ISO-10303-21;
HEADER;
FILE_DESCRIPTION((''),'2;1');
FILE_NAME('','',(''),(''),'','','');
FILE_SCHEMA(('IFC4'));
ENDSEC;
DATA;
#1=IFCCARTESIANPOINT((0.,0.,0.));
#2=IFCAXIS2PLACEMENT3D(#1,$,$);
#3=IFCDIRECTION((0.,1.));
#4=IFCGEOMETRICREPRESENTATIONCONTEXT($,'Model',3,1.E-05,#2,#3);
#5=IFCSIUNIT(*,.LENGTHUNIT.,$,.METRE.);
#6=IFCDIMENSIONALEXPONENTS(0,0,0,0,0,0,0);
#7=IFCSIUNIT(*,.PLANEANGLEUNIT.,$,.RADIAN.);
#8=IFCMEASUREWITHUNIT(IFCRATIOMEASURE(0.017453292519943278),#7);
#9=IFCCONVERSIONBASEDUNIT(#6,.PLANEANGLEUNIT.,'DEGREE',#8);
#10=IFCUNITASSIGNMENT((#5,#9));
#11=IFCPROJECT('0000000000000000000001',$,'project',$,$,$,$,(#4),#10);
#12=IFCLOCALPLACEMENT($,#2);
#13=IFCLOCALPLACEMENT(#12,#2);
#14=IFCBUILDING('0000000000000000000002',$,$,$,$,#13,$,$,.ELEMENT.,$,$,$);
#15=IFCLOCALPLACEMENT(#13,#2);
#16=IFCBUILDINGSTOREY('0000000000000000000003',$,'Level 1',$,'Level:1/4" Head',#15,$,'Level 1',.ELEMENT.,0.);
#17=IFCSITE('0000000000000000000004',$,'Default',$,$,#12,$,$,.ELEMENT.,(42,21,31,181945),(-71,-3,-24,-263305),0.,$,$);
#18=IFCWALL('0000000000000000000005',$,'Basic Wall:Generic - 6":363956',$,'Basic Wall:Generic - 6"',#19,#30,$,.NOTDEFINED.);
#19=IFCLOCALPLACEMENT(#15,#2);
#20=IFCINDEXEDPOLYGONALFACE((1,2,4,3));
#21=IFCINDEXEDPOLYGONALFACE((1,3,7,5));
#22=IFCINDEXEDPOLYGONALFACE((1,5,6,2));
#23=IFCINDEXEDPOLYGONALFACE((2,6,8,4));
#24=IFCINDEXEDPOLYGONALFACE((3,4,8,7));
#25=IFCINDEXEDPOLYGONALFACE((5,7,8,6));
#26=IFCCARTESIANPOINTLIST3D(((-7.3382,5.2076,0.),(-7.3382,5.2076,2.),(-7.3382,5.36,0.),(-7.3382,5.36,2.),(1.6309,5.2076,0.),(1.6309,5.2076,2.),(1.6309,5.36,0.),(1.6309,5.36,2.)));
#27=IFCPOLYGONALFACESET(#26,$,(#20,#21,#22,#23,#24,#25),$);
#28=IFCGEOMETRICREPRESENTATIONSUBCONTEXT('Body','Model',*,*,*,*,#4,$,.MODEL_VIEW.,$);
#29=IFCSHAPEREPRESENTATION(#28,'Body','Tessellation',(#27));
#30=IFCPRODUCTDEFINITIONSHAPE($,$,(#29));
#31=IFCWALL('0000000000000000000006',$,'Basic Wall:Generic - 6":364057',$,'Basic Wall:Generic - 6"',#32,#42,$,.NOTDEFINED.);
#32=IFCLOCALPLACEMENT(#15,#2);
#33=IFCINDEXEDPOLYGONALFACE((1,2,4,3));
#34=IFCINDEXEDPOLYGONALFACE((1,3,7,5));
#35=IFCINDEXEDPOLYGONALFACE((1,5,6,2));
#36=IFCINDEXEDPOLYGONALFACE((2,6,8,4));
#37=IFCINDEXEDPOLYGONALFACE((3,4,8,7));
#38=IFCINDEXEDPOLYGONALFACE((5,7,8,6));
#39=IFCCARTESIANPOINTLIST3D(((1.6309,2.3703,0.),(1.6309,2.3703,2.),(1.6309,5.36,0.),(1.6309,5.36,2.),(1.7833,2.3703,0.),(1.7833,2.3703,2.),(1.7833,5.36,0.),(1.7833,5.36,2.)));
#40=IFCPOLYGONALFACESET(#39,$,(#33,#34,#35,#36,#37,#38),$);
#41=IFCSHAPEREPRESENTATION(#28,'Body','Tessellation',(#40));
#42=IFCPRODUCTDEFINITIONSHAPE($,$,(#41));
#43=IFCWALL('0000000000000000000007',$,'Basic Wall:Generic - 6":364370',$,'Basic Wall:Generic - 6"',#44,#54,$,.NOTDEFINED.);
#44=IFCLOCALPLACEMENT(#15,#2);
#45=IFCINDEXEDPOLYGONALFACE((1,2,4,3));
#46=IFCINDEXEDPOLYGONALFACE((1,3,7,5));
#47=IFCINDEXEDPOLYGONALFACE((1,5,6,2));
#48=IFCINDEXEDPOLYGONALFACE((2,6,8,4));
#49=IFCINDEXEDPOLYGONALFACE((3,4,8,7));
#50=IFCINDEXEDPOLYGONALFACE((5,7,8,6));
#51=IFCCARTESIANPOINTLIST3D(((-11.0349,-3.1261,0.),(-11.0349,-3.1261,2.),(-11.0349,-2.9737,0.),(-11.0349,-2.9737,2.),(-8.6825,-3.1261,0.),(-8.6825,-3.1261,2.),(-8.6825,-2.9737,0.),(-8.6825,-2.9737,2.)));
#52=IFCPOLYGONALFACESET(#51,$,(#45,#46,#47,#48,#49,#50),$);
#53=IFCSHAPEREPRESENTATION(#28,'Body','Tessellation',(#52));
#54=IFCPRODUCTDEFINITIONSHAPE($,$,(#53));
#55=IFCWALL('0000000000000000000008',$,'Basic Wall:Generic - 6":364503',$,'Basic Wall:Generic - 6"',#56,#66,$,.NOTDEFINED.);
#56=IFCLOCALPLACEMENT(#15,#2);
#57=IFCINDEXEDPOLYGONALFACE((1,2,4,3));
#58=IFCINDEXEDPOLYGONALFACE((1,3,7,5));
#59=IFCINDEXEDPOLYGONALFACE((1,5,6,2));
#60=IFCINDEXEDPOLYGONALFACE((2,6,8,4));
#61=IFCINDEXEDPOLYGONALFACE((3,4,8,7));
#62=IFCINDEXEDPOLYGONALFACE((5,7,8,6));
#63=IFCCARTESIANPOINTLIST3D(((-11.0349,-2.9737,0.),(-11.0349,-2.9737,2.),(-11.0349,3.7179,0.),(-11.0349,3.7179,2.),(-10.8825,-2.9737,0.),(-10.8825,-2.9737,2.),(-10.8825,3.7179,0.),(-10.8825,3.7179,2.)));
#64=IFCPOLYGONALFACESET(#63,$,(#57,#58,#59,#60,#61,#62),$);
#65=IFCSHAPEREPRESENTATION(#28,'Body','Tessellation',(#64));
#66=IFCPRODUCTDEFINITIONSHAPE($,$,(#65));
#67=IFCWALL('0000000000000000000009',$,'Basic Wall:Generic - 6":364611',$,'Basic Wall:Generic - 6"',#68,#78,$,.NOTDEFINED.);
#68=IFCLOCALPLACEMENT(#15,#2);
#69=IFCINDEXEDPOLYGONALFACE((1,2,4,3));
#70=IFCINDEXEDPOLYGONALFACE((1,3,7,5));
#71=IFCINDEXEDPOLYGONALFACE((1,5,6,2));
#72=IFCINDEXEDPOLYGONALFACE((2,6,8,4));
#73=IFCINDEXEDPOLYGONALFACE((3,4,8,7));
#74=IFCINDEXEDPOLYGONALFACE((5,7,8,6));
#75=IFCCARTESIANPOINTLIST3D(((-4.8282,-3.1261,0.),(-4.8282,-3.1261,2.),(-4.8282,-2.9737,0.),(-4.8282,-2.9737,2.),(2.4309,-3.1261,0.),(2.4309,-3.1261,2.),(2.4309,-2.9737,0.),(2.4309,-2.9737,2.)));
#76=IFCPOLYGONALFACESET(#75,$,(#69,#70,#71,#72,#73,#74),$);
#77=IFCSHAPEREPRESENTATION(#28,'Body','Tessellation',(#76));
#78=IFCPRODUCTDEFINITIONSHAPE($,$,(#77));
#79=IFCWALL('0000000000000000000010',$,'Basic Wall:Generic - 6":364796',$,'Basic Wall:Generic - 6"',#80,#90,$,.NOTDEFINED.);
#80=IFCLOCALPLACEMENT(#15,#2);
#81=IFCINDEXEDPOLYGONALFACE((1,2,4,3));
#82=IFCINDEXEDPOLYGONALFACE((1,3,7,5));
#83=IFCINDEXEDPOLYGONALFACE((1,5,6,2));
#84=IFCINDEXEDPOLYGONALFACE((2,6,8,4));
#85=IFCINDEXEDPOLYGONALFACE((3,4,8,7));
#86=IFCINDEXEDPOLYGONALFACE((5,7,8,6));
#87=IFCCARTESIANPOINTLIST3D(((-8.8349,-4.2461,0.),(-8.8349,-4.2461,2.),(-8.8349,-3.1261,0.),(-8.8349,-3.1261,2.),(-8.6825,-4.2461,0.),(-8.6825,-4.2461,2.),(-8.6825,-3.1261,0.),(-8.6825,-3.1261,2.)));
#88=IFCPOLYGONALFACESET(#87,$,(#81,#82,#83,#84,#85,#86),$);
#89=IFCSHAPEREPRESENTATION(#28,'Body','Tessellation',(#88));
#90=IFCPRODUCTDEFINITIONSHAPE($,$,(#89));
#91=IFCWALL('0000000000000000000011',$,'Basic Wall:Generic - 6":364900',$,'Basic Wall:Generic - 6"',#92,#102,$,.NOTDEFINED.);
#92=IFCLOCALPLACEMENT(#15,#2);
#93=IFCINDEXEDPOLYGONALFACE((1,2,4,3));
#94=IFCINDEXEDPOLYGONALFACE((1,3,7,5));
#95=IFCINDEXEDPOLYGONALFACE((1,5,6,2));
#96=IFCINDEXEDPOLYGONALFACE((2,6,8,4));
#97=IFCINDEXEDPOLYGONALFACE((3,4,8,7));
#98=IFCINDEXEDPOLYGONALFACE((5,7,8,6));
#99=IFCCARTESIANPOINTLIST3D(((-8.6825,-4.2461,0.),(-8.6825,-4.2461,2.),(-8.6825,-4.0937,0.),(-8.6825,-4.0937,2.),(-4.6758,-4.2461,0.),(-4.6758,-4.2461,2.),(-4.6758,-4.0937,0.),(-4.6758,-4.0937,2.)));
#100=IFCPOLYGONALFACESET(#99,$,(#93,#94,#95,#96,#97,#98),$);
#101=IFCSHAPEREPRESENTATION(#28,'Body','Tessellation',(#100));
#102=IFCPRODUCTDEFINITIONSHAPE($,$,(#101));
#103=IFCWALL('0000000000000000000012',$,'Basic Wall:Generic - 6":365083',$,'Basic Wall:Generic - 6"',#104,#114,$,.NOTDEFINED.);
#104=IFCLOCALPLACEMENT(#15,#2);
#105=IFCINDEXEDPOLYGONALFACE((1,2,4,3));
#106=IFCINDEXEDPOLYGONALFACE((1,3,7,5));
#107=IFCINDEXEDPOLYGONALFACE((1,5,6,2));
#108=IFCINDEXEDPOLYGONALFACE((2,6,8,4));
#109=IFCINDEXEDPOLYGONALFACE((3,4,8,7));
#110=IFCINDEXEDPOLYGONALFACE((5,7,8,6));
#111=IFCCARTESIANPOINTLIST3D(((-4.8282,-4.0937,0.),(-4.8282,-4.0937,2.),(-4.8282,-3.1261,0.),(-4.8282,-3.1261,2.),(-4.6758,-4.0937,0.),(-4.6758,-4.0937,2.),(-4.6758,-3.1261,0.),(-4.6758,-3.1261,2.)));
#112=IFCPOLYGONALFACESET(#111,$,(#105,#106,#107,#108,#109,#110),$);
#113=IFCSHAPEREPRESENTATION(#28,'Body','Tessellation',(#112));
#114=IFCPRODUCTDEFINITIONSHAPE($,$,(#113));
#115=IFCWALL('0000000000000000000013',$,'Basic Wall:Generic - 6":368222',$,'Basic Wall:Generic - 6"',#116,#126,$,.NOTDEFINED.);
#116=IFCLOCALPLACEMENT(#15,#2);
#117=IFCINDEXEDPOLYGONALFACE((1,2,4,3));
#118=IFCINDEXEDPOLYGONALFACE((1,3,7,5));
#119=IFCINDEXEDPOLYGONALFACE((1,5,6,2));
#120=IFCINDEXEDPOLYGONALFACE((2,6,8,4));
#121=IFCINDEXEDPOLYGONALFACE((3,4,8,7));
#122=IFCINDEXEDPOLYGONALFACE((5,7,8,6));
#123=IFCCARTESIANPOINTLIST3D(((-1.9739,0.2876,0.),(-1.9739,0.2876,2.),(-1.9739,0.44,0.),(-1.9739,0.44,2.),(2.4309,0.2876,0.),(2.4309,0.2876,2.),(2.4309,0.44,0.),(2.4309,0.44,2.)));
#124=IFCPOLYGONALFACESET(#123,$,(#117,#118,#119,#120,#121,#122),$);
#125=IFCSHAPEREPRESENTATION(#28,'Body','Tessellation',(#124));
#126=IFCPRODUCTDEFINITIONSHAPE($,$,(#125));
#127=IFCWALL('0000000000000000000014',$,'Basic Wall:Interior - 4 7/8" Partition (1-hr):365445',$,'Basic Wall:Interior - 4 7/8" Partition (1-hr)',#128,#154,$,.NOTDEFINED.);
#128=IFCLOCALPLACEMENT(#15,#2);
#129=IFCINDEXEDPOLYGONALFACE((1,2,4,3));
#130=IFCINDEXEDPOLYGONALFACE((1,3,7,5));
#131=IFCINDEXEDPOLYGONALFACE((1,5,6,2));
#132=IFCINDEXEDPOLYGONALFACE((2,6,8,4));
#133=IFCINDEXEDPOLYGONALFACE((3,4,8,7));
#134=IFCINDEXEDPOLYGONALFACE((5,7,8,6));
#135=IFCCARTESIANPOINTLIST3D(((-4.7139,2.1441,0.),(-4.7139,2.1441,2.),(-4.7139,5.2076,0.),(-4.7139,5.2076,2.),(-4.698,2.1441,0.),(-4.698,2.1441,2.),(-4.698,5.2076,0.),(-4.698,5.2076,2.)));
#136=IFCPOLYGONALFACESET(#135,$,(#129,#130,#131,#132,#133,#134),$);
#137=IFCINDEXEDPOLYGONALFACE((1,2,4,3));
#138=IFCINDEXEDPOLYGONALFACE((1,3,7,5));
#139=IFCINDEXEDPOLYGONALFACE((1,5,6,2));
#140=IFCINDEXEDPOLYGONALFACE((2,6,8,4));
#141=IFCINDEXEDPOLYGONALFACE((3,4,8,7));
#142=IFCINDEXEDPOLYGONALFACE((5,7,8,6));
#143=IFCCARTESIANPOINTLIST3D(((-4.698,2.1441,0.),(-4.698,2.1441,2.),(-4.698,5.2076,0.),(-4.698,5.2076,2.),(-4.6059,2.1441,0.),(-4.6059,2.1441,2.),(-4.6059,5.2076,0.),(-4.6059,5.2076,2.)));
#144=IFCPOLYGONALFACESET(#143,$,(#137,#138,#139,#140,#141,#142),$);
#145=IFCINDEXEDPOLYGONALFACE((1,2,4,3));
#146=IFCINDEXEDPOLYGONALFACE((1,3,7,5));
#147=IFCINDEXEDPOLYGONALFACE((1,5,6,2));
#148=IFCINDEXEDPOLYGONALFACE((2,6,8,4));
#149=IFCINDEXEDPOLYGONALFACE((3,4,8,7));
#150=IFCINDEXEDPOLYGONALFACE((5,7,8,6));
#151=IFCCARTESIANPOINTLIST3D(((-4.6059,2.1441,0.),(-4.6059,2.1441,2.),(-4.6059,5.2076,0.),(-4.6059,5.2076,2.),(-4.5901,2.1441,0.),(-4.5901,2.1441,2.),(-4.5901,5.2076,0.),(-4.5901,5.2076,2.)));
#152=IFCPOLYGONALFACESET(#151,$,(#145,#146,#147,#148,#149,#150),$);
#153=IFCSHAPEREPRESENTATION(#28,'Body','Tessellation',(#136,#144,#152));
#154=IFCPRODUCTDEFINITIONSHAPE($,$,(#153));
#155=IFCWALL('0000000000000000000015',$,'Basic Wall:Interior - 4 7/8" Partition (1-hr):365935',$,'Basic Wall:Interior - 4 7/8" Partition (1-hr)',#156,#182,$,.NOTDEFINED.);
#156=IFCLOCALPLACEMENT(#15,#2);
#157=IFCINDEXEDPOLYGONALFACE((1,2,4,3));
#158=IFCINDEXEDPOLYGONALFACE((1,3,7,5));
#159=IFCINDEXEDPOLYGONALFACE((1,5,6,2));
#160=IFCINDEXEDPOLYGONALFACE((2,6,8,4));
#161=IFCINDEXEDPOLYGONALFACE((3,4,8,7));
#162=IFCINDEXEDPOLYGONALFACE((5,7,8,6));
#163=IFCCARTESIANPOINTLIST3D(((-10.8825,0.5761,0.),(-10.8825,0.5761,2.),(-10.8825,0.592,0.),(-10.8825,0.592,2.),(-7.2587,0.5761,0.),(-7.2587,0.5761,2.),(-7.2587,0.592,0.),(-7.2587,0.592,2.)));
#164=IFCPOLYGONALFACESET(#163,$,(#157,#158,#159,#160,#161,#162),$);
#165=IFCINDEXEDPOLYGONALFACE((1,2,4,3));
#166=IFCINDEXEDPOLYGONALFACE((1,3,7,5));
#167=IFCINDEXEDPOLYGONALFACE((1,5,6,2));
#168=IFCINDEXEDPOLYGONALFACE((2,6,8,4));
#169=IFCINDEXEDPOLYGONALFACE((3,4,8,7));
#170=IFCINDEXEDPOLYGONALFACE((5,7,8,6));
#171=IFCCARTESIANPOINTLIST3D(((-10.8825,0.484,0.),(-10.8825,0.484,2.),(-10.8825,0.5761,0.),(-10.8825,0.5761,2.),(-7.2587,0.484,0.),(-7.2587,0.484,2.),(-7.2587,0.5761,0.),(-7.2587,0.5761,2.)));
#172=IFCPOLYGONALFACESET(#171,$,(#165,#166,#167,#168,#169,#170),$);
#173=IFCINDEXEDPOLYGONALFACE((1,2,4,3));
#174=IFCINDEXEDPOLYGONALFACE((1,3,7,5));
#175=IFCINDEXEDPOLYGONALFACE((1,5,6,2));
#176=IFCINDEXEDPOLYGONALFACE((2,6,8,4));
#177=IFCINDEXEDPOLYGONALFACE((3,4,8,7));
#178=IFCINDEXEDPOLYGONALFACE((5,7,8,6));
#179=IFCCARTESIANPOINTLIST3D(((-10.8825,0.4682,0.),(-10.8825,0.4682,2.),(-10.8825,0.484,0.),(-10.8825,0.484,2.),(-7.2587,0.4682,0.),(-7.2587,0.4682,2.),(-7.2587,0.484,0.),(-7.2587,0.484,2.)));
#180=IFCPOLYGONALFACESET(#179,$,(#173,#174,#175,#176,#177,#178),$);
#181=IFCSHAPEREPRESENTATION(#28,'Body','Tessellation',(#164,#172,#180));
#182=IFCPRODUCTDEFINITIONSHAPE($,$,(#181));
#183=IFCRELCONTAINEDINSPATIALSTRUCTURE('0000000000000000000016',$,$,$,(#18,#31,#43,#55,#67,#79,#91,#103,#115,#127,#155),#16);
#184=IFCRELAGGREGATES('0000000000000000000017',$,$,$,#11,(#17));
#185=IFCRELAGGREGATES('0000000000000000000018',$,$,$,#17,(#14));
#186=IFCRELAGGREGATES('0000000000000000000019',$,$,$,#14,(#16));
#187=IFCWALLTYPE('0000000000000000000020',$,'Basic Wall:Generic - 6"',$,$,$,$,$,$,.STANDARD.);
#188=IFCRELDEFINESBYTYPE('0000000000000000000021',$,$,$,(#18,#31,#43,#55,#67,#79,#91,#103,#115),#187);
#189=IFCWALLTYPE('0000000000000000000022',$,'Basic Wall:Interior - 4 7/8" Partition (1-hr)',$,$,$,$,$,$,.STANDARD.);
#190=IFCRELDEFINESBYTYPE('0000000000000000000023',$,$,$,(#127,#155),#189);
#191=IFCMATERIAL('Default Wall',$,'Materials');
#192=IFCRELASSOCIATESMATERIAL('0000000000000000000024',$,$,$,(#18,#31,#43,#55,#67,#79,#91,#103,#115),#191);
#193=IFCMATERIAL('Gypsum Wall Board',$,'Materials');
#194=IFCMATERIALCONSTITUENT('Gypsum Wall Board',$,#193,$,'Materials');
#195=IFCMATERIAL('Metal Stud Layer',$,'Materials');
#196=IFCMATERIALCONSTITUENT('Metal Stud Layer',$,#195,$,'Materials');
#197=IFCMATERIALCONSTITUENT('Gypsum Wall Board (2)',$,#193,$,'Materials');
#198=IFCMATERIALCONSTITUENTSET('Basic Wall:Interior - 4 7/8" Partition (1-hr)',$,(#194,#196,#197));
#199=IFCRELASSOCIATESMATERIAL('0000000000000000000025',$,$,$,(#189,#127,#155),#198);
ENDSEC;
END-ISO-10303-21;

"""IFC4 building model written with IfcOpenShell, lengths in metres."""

from ifc_helpers import new_model, entity, si_unit, converted_unit, direction, frame, origin, place, context, subcontext, project, spatial, indexed_curve, outline, extrude, material, constituent, constituent_set, type_object, element, save


model = new_model("IFC4")

# Units and contexts
model_context = context("Model", 3, precision=1e-05, world=origin(), true_north=direction((0.0, 1.0)))
body_context = subcontext(model_context, "Body", "Model", "MODEL_VIEW")
ifc_project = project(units=[si_unit("LENGTHUNIT", "METRE"), converted_unit("PLANEANGLEUNIT", "DEGREE", entity("IfcRatioMeasure", 0.017453292519943278), si_unit("PLANEANGLEUNIT", "RADIAN"), dimensions=[0, 0, 0, 0, 0, 0, 0])], contexts=[model_context])

# Site, building, storey
site_placement = place(None, origin())
site = spatial("IfcSite", under=ifc_project, at=site_placement, Name="Default", CompositionType="ELEMENT", RefLatitude=(42, 21, 31, 181945), RefLongitude=(-71, -3, -24, -263305), RefElevation=0.0)
building_placement = place(site_placement, origin())
building = spatial("IfcBuilding", under=site, at=building_placement, CompositionType="ELEMENT")
storey_placement = place(building_placement, origin())
storey = spatial("IfcBuildingStorey", under=building, at=storey_placement, Name="Level 1", ObjectType="Level:1/4\" Head", LongName="Level 1", CompositionType="ELEMENT", Elevation=0.0)

# Walls
ifc_material_1 = material(Name="Default Wall", Category="Materials")
wall_type_1 = type_object("IfcWallType", Name="Basic Wall:Generic - 6\"", PredefinedType="STANDARD")
wall_1_placement = place(storey_placement, frame((1.6309, 5.2838, 0.0), z_axis=(0.0, 0.0, 1.0), x_axis=(-1.0, 0.0, 0.0)))
element("IfcWall", 1, at=wall_1_placement, inside=storey, type_object=wall_type_1, material=ifc_material_1, Name="Basic Wall:Generic - 6\":363956", ObjectType="Basic Wall:Generic - 6\"", PredefinedType="NOTDEFINED", context=body_context, shape_type="SweptSolid", body=[
    extrude(outline(indexed_curve([(8.9691, 0.0762), (0.0, 0.0762), (0.0, -0.0762), (8.9691, -0.0762), (8.9691, 0.0762)], self_intersect=False)), origin(), (0.0, 0.0, 1.0), 2.0),
])
wall_2_placement = place(storey_placement, frame((1.7071, 5.36, 0.0), z_axis=(0.0, 0.0, 1.0), x_axis=(0.0, -1.0, 0.0)))
element("IfcWall", 2, at=wall_2_placement, inside=storey, type_object=wall_type_1, material=ifc_material_1, Name="Basic Wall:Generic - 6\":364057", ObjectType="Basic Wall:Generic - 6\"", PredefinedType="NOTDEFINED", context=body_context, shape_type="SweptSolid", body=[
    extrude(outline(indexed_curve([(2.9897, 0.0762), (0.0, 0.0762), (0.0, -0.0762), (2.9897, -0.0762), (2.9897, 0.0762)], self_intersect=False)), origin(), (0.0, 0.0, 1.0), 2.0),
])
wall_3_placement = place(storey_placement, frame((-8.6825, -3.0499, 0.0), z_axis=(0.0, 0.0, 1.0), x_axis=(-1.0, 0.0, 0.0)))
element("IfcWall", 3, at=wall_3_placement, inside=storey, type_object=wall_type_1, material=ifc_material_1, Name="Basic Wall:Generic - 6\":364370", ObjectType="Basic Wall:Generic - 6\"", PredefinedType="NOTDEFINED", context=body_context, shape_type="SweptSolid", body=[
    extrude(outline(indexed_curve([(2.3524, 0.0762), (0.0, 0.0762), (0.0, -0.0762), (2.3524, -0.0762), (2.3524, 0.0762)], self_intersect=False)), origin(), (0.0, 0.0, 1.0), 2.0),
])
wall_4_placement = place(storey_placement, frame((-10.9587, 3.7179, 0.0), z_axis=(0.0, 0.0, 1.0), x_axis=(0.0, -1.0, 0.0)))
element("IfcWall", 4, at=wall_4_placement, inside=storey, type_object=wall_type_1, material=ifc_material_1, Name="Basic Wall:Generic - 6\":364503", ObjectType="Basic Wall:Generic - 6\"", PredefinedType="NOTDEFINED", context=body_context, shape_type="SweptSolid", body=[
    extrude(outline(indexed_curve([(6.6916, 0.0762), (0.0, 0.0762), (0.0, -0.0762), (6.6916, -0.0762), (6.6916, 0.0762)], self_intersect=False)), origin(), (0.0, 0.0, 1.0), 2.0),
])
wall_5_placement = place(storey_placement, frame((2.4309, -3.0499, 0.0), z_axis=(0.0, 0.0, 1.0), x_axis=(-1.0, 0.0, 0.0)))
element("IfcWall", 5, at=wall_5_placement, inside=storey, type_object=wall_type_1, material=ifc_material_1, Name="Basic Wall:Generic - 6\":364611", ObjectType="Basic Wall:Generic - 6\"", PredefinedType="NOTDEFINED", context=body_context, shape_type="SweptSolid", body=[
    extrude(outline(indexed_curve([(7.2591, 0.0762), (0.0, 0.0762), (0.0, -0.0762), (7.2591, -0.0762), (7.2591, 0.0762)], self_intersect=False)), origin(), (0.0, 0.0, 1.0), 2.0),
])
wall_6_placement = place(storey_placement, frame((-8.7587, -3.1261, 0.0), z_axis=(0.0, 0.0, 1.0), x_axis=(0.0, -1.0, 0.0)))
element("IfcWall", 6, at=wall_6_placement, inside=storey, type_object=wall_type_1, material=ifc_material_1, Name="Basic Wall:Generic - 6\":364796", ObjectType="Basic Wall:Generic - 6\"", PredefinedType="NOTDEFINED", context=body_context, shape_type="SweptSolid", body=[
    extrude(outline(indexed_curve([(1.12, 0.0762), (0.0, 0.0762), (0.0, -0.0762), (1.12, -0.0762), (1.12, 0.0762)], self_intersect=False)), origin(), (0.0, 0.0, 1.0), 2.0),
])
wall_7_placement = place(storey_placement, frame((-4.6758, -4.1699, 0.0), z_axis=(0.0, 0.0, 1.0), x_axis=(-1.0, 0.0, 0.0)))
element("IfcWall", 7, at=wall_7_placement, inside=storey, type_object=wall_type_1, material=ifc_material_1, Name="Basic Wall:Generic - 6\":364900", ObjectType="Basic Wall:Generic - 6\"", PredefinedType="NOTDEFINED", context=body_context, shape_type="SweptSolid", body=[
    extrude(outline(indexed_curve([(4.0068, 0.0762), (0.0, 0.0762), (0.0, -0.0762), (4.0068, -0.0762), (4.0068, 0.0762)], self_intersect=False)), origin(), (0.0, 0.0, 1.0), 2.0),
])
wall_8_placement = place(storey_placement, frame((-4.752, -4.0937, 0.0), z_axis=(0.0, 0.0, 1.0), x_axis=(0.0, 1.0, 0.0)))
element("IfcWall", 8, at=wall_8_placement, inside=storey, type_object=wall_type_1, material=ifc_material_1, Name="Basic Wall:Generic - 6\":365083", ObjectType="Basic Wall:Generic - 6\"", PredefinedType="NOTDEFINED", context=body_context, shape_type="SweptSolid", body=[
    extrude(outline(indexed_curve([(0.9676, 0.0762), (0.0, 0.0762), (0.0, -0.0762), (0.9676, -0.0762), (0.9676, 0.0762)], self_intersect=False)), origin(), (0.0, 0.0, 1.0), 2.0),
])
wall_9_placement = place(storey_placement, frame((-1.9739, 0.3638, 0.0)))
element("IfcWall", 9, at=wall_9_placement, inside=storey, type_object=wall_type_1, material=ifc_material_1, Name="Basic Wall:Generic - 6\":368222", ObjectType="Basic Wall:Generic - 6\"", PredefinedType="NOTDEFINED", context=body_context, shape_type="SweptSolid", body=[
    extrude(outline(indexed_curve([(4.4048, 0.0762), (0.0, 0.0762), (0.0, -0.0762), (4.4048, -0.0762), (4.4048, 0.0762)], self_intersect=False)), origin(), (0.0, 0.0, 1.0), 2.0),
])
ifc_material_2 = material(Name="Gypsum Wall Board", Category="Materials")
ifc_constituent_1 = constituent(ifc_material_2, Name="Gypsum Wall Board", Category="Materials")
ifc_material_3 = material(Name="Metal Stud Layer", Category="Materials")
ifc_constituent_2 = constituent(ifc_material_3, Name="Metal Stud Layer", Category="Materials")
ifc_constituent_3 = constituent(ifc_material_2, Name="Gypsum Wall Board (2)", Category="Materials")
ifc_constituent_set = constituent_set(constituents=[ifc_constituent_1, ifc_constituent_2, ifc_constituent_3], Name="Basic Wall:Interior - 4 7/8\" Partition (1-hr)")
wall_type_2 = type_object("IfcWallType", Name="Basic Wall:Interior - 4 7/8\" Partition (1-hr)", PredefinedType="STANDARD", material=ifc_constituent_set)
wall_10_placement = place(storey_placement, frame((-4.652, 5.2076, 0.0), z_axis=(0.0, 0.0, 1.0), x_axis=(0.0, -1.0, 0.0)))
element("IfcWall", 10, at=wall_10_placement, inside=storey, type_object=wall_type_2, material=ifc_constituent_set, Name="Basic Wall:Interior - 4 7/8\" Partition (1-hr):365445", ObjectType="Basic Wall:Interior - 4 7/8\" Partition (1-hr)", PredefinedType="NOTDEFINED", context=body_context, shape_type="SweptSolid", body=[
    extrude(outline(indexed_curve([(-0.0079, -1.5318), (0.0079, -1.5318), (0.0079, 1.5318), (-0.0079, 1.5318), (-0.0079, -1.5318)], self_intersect=False)), frame((1.5318, -0.054, 0.0), z_axis=(0.0, 0.0, 1.0), x_axis=(0.0, 1.0, 0.0)), (0.0, 0.0, 1.0), 2.0),
    extrude(outline(indexed_curve([(-1.5318, -0.046), (1.5318, -0.046), (1.5318, 0.046), (-1.5318, 0.046), (-1.5318, -0.046)], self_intersect=False)), frame((1.5318, 0.0, 0.0)), (0.0, 0.0, 1.0), 2.0),
    extrude(outline(indexed_curve([(-0.0079, -1.5318), (0.0079, -1.5318), (0.0079, 1.5318), (-0.0079, 1.5318), (-0.0079, -1.5318)], self_intersect=False)), frame((1.5318, 0.054, 0.0), z_axis=(0.0, 0.0, 1.0), x_axis=(0.0, -1.0, 0.0)), (0.0, 0.0, 1.0), 2.0),
])
wall_11_placement = place(storey_placement, frame((-10.8825, 0.5301, 0.0)))
element("IfcWall", 11, at=wall_11_placement, inside=storey, type_object=wall_type_2, material=ifc_constituent_set, Name="Basic Wall:Interior - 4 7/8\" Partition (1-hr):365935", ObjectType="Basic Wall:Interior - 4 7/8\" Partition (1-hr)", PredefinedType="NOTDEFINED", context=body_context, shape_type="SweptSolid", body=[
    extrude(outline(indexed_curve([(-0.0079, -1.8119), (0.0079, -1.8119), (0.0079, 1.8119), (-0.0079, 1.8119), (-0.0079, -1.8119)], self_intersect=False)), frame((1.8119, 0.054, 0.0), z_axis=(0.0, 0.0, 1.0), x_axis=(0.0, -1.0, 0.0)), (0.0, 0.0, 1.0), 2.0),
    extrude(outline(indexed_curve([(-1.8119, -0.046), (1.8119, -0.046), (1.8119, 0.046), (-1.8119, 0.046), (-1.8119, -0.046)], self_intersect=False)), frame((1.8119, 0.0, 0.0)), (0.0, 0.0, 1.0), 2.0),
    extrude(outline(indexed_curve([(-0.0079, -1.8119), (0.0079, -1.8119), (0.0079, 1.8119), (-0.0079, 1.8119), (-0.0079, -1.8119)], self_intersect=False)), frame((1.8119, -0.054, 0.0), z_axis=(0.0, 0.0, 1.0), x_axis=(0.0, 1.0, 0.0)), (0.0, 0.0, 1.0), 2.0),
])

save(model, "model.ifc")
